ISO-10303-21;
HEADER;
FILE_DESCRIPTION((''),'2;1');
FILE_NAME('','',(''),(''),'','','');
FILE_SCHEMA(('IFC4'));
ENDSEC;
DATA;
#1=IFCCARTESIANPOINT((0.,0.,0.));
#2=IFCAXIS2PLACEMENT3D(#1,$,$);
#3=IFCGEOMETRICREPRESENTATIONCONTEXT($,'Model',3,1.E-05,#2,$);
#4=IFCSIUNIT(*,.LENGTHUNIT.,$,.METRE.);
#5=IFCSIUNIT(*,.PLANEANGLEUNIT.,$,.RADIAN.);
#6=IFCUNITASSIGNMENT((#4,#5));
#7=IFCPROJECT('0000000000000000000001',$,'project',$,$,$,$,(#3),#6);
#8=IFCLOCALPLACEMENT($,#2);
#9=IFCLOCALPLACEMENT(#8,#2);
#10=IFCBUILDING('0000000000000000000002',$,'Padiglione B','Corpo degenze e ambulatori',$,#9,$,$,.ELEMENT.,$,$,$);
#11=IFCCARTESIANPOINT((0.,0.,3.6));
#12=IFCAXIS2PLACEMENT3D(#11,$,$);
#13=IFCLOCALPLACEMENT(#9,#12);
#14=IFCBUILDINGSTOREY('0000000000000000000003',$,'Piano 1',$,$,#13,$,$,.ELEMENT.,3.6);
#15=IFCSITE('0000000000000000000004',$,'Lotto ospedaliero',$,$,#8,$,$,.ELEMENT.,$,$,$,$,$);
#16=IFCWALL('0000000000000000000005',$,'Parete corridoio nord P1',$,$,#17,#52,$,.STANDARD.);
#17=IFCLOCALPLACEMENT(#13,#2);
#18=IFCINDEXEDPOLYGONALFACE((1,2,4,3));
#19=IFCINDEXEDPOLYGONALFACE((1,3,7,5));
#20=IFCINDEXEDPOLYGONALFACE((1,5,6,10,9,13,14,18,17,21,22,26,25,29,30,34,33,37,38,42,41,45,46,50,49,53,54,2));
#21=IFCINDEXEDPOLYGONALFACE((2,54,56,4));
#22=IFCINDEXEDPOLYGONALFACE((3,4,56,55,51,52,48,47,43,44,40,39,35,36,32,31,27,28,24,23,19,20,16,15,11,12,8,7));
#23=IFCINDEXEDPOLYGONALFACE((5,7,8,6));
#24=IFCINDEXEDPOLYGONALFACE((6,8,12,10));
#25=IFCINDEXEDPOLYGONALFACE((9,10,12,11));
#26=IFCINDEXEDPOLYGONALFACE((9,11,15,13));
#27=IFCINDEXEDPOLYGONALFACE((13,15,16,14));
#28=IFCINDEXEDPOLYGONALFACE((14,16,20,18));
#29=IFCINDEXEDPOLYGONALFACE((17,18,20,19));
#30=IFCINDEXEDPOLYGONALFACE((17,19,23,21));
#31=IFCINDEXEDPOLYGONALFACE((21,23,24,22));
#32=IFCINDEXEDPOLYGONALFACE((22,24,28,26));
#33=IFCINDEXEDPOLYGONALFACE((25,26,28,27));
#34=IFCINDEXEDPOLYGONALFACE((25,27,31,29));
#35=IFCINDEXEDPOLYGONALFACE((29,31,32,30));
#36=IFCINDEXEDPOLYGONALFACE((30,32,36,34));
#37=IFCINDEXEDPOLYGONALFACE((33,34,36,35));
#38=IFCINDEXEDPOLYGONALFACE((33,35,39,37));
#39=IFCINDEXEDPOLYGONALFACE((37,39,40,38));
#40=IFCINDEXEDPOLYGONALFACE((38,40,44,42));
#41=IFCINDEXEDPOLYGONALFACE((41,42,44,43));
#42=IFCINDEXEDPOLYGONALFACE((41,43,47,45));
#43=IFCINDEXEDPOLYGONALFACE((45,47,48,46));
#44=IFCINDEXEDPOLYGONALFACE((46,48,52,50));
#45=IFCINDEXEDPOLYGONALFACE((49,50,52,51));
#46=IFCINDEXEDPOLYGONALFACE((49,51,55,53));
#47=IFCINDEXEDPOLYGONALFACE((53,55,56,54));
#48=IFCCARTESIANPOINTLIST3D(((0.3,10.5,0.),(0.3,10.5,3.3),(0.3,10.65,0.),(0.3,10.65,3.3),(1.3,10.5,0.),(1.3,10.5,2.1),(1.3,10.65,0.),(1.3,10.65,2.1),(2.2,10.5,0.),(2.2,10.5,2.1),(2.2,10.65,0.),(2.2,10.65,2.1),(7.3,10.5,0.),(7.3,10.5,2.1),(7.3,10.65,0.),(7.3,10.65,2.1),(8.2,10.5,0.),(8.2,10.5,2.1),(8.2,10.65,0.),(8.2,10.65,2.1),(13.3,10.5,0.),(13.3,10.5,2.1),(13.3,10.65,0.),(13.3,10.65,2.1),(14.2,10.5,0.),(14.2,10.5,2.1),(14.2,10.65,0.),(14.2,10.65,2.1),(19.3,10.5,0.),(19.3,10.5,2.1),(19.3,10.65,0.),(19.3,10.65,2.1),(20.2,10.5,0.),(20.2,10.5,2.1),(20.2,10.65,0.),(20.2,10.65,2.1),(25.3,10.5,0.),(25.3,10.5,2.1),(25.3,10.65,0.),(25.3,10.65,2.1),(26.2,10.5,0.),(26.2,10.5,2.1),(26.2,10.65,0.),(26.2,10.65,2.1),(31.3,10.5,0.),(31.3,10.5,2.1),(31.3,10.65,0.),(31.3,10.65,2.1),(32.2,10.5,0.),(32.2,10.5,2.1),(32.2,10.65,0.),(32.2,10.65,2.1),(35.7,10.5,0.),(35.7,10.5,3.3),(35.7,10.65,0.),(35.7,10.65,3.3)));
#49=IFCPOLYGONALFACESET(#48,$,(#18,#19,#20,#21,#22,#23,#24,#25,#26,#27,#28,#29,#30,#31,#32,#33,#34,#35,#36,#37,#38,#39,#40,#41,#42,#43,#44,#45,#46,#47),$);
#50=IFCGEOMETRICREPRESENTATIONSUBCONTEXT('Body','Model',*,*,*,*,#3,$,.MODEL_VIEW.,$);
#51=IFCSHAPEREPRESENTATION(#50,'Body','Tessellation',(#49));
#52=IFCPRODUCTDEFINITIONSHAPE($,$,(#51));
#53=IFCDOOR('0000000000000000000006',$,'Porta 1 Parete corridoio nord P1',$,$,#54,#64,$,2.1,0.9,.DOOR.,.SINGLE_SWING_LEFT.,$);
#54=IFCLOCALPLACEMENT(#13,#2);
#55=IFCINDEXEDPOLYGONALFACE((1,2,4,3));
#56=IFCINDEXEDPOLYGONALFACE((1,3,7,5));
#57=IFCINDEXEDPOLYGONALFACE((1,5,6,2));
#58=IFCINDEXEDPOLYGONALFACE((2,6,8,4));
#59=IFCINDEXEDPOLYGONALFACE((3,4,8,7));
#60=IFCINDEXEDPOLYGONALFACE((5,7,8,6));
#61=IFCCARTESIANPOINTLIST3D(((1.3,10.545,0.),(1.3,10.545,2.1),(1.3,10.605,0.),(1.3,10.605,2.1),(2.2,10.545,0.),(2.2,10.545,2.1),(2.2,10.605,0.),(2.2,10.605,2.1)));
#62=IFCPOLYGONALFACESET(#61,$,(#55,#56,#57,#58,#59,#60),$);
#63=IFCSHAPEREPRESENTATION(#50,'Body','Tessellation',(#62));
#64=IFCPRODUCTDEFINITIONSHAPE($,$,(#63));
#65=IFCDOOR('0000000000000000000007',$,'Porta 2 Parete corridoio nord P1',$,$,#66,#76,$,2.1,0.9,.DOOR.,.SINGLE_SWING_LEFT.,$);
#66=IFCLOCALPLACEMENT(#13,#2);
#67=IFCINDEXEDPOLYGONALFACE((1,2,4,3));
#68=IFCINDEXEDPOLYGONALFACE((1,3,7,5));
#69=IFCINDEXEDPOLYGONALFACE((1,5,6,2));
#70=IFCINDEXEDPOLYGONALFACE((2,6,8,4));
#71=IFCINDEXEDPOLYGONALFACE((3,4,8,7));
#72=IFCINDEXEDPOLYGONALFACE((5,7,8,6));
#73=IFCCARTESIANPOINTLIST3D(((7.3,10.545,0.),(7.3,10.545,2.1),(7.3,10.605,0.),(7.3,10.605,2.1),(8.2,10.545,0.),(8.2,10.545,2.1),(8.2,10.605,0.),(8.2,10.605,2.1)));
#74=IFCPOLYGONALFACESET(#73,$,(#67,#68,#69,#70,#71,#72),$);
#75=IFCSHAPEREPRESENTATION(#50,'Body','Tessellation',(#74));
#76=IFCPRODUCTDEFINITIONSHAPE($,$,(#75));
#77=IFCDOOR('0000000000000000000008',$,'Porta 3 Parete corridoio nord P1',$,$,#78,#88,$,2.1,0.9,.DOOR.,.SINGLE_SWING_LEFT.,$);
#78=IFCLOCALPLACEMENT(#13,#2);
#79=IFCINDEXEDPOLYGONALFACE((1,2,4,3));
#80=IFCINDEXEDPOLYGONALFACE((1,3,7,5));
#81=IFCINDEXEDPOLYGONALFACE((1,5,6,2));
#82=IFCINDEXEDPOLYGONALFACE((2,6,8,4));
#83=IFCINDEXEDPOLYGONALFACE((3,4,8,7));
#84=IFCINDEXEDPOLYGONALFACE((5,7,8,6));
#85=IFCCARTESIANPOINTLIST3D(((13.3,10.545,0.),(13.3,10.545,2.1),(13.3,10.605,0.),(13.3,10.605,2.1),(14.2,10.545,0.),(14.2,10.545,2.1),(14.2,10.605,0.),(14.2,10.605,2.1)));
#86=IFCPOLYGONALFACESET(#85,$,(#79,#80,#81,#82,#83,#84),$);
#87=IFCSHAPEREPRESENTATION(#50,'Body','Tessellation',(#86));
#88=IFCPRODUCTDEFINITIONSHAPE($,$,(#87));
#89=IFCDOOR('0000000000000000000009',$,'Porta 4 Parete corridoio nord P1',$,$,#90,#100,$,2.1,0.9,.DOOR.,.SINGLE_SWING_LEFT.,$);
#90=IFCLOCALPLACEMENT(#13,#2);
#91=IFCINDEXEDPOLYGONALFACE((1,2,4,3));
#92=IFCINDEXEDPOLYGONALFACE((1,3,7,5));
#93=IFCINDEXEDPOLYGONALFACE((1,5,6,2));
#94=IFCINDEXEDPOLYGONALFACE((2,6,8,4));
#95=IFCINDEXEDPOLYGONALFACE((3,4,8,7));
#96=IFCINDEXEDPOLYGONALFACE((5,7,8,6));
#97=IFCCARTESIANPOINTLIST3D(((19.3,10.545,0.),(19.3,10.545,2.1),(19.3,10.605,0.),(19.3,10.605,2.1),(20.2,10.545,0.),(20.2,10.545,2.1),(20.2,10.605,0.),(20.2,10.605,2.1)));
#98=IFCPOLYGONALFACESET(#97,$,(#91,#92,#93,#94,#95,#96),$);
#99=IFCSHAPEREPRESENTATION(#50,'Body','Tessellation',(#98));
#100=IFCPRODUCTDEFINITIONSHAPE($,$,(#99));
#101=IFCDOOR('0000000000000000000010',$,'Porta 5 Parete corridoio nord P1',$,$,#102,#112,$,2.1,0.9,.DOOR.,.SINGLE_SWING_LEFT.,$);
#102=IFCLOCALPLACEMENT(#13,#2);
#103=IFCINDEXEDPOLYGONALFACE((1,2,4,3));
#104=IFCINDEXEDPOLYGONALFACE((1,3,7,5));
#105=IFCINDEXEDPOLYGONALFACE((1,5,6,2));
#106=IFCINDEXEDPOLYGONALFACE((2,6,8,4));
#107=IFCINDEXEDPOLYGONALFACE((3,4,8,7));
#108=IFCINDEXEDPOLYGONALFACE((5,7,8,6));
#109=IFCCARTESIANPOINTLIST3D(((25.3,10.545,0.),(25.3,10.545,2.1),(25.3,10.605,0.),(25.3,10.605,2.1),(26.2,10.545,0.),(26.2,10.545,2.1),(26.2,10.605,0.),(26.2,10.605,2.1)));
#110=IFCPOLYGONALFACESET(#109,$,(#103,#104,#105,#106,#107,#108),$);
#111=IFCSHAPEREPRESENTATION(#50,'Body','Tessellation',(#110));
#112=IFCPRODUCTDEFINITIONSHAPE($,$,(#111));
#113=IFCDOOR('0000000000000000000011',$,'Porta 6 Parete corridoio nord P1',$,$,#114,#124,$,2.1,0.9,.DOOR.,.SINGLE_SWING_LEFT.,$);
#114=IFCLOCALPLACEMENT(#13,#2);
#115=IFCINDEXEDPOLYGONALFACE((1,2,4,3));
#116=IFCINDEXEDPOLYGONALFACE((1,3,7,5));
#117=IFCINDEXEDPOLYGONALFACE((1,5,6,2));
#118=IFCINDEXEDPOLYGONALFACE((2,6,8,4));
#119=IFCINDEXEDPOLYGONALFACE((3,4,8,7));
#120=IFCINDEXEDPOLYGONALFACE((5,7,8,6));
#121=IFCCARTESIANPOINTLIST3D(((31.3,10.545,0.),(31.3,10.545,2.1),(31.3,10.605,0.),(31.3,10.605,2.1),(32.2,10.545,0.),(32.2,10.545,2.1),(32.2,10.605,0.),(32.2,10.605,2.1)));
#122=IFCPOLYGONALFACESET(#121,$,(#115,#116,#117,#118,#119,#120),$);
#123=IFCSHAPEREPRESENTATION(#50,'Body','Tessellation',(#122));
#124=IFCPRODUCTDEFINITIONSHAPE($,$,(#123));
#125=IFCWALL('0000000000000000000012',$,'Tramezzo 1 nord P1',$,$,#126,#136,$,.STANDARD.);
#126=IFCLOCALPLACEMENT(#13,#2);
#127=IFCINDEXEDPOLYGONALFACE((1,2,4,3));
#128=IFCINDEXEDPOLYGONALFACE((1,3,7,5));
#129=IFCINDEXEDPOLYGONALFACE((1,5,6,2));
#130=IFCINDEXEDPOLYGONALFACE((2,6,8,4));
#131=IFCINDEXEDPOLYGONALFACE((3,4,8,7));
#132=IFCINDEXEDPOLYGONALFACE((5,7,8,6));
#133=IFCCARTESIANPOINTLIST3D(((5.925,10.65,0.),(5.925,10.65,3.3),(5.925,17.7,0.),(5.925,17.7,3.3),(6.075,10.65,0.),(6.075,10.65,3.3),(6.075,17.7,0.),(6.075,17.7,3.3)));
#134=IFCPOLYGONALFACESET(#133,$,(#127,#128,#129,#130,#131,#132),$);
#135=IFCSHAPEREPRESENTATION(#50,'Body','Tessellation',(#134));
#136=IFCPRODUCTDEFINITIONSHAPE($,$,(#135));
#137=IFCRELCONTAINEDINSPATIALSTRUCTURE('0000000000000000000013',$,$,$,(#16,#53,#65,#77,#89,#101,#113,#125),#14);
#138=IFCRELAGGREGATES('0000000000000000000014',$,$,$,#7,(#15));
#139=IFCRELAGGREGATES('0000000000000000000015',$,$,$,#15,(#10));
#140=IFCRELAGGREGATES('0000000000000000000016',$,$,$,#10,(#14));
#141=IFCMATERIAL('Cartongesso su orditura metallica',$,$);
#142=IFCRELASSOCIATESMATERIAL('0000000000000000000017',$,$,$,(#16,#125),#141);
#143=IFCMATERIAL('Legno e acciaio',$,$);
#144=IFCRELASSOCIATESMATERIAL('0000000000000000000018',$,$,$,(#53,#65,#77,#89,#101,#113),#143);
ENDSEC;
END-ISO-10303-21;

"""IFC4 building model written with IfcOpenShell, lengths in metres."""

from ifc_helpers import new_model, si_unit, frame, frame_2d, origin, place, context, subcontext, project, spatial, rectangle, extrude, material, element, fill, save


model = new_model("IFC4")

# Units and contexts
model_context = context("Model", 3, precision=1e-05, world=origin())
body_context = subcontext(model_context, "Body", "Model", "MODEL_VIEW")
ifc_project = project(units=[si_unit("LENGTHUNIT", "METRE"), si_unit("PLANEANGLEUNIT", "RADIAN")], contexts=[model_context])

# Site, building, storey
site_placement = place(None, origin())
site = spatial("IfcSite", under=ifc_project, at=site_placement, Name="Lotto ospedaliero", CompositionType="ELEMENT")
building_placement = place(site_placement, origin())
building = spatial("IfcBuilding", under=site, at=building_placement, Name="Padiglione B", Description="Corpo degenze e ambulatori", CompositionType="ELEMENT")
storey_placement = place(building_placement, frame((0.0, 0.0, 3.6)))
storey = spatial("IfcBuildingStorey", under=building, at=storey_placement, Name="Piano 1", CompositionType="ELEMENT", Elevation=3.6)

# Wall, openings, doors
ifc_material_1 = material(Name="Cartongesso su orditura metallica")
ifc_material_2 = material(Name="Legno e acciaio")
wall_1_placement = place(storey_placement, frame((0.3, 10.5, 0.0)))
wall_1 = element("IfcWall", 1, at=wall_1_placement, inside=storey, material=ifc_material_1, Name="Parete corridoio nord P1", PredefinedType="STANDARD", context=body_context, shape_type="SweptSolid", body=[
    extrude(rectangle(XDim=35.4, YDim=0.15, at=frame_2d((17.7, 0.075))), origin(), (0.0, 0.0, 1.0), 3.3),
])
opening_1_placement = place(wall_1_placement, frame((1.0, -0.1, 0.0)))
opening_1 = element("IfcOpeningElement", 2, at=opening_1_placement, cuts=wall_1, PredefinedType="OPENING", context=body_context, shape_type="SweptSolid", body=[
    extrude(rectangle(XDim=0.9, YDim=0.35, at=frame_2d((0.45, 0.175))), origin(), (0.0, 0.0, 1.0), 2.1),
])
opening_2_placement = place(wall_1_placement, frame((7.0, -0.1, 0.0)))
opening_2 = element("IfcOpeningElement", 3, at=opening_2_placement, cuts=wall_1, PredefinedType="OPENING", context=body_context, shape_type="SweptSolid", body=[
    extrude(rectangle(XDim=0.9, YDim=0.35, at=frame_2d((0.45, 0.175))), origin(), (0.0, 0.0, 1.0), 2.1),
])
opening_3_placement = place(wall_1_placement, frame((13.0, -0.1, 0.0)))
opening_3 = element("IfcOpeningElement", 4, at=opening_3_placement, cuts=wall_1, PredefinedType="OPENING", context=body_context, shape_type="SweptSolid", body=[
    extrude(rectangle(XDim=0.9, YDim=0.35, at=frame_2d((0.45, 0.175))), origin(), (0.0, 0.0, 1.0), 2.1),
])
opening_4_placement = place(wall_1_placement, frame((19.0, -0.1, 0.0)))
opening_4 = element("IfcOpeningElement", 5, at=opening_4_placement, cuts=wall_1, PredefinedType="OPENING", context=body_context, shape_type="SweptSolid", body=[
    extrude(rectangle(XDim=0.9, YDim=0.35, at=frame_2d((0.45, 0.175))), origin(), (0.0, 0.0, 1.0), 2.1),
])
opening_5_placement = place(wall_1_placement, frame((25.0, -0.1, 0.0)))
opening_5 = element("IfcOpeningElement", 6, at=opening_5_placement, cuts=wall_1, PredefinedType="OPENING", context=body_context, shape_type="SweptSolid", body=[
    extrude(rectangle(XDim=0.9, YDim=0.35, at=frame_2d((0.45, 0.175))), origin(), (0.0, 0.0, 1.0), 2.1),
])
opening_6_placement = place(wall_1_placement, frame((31.0, -0.1, 0.0)))
opening_6 = element("IfcOpeningElement", 7, at=opening_6_placement, cuts=wall_1, PredefinedType="OPENING", context=body_context, shape_type="SweptSolid", body=[
    extrude(rectangle(XDim=0.9, YDim=0.35, at=frame_2d((0.45, 0.175))), origin(), (0.0, 0.0, 1.0), 2.1),
])
door_1_placement = place(wall_1_placement, frame((1.0, 0.045, 0.0)))
door_1 = element("IfcDoor", 8, at=door_1_placement, inside=storey, material=ifc_material_2, Name="Porta 1 Parete corridoio nord P1", OperationType="SINGLE_SWING_LEFT", OverallHeight=2.1, OverallWidth=0.9, PredefinedType="DOOR", context=body_context, shape_type="SweptSolid", body=[
    extrude(rectangle(XDim=0.9, YDim=0.06, at=frame_2d((0.45, 0.03))), origin(), (0.0, 0.0, 1.0), 2.1),
])
fill(opening_1, door_1)
door_2_placement = place(wall_1_placement, frame((7.0, 0.045, 0.0)))
door_2 = element("IfcDoor", 9, at=door_2_placement, inside=storey, material=ifc_material_2, Name="Porta 2 Parete corridoio nord P1", OperationType="SINGLE_SWING_LEFT", OverallHeight=2.1, OverallWidth=0.9, PredefinedType="DOOR", context=body_context, shape_type="SweptSolid", body=[
    extrude(rectangle(XDim=0.9, YDim=0.06, at=frame_2d((0.45, 0.03))), origin(), (0.0, 0.0, 1.0), 2.1),
])
fill(opening_2, door_2)
door_3_placement = place(wall_1_placement, frame((13.0, 0.045, 0.0)))
door_3 = element("IfcDoor", 10, at=door_3_placement, inside=storey, material=ifc_material_2, Name="Porta 3 Parete corridoio nord P1", OperationType="SINGLE_SWING_LEFT", OverallHeight=2.1, OverallWidth=0.9, PredefinedType="DOOR", context=body_context, shape_type="SweptSolid", body=[
    extrude(rectangle(XDim=0.9, YDim=0.06, at=frame_2d((0.45, 0.03))), origin(), (0.0, 0.0, 1.0), 2.1),
])
fill(opening_3, door_3)
door_4_placement = place(wall_1_placement, frame((19.0, 0.045, 0.0)))
door_4 = element("IfcDoor", 11, at=door_4_placement, inside=storey, material=ifc_material_2, Name="Porta 4 Parete corridoio nord P1", OperationType="SINGLE_SWING_LEFT", OverallHeight=2.1, OverallWidth=0.9, PredefinedType="DOOR", context=body_context, shape_type="SweptSolid", body=[
    extrude(rectangle(XDim=0.9, YDim=0.06, at=frame_2d((0.45, 0.03))), origin(), (0.0, 0.0, 1.0), 2.1),
])
fill(opening_4, door_4)
door_5_placement = place(wall_1_placement, frame((25.0, 0.045, 0.0)))
door_5 = element("IfcDoor", 12, at=door_5_placement, inside=storey, material=ifc_material_2, Name="Porta 5 Parete corridoio nord P1", OperationType="SINGLE_SWING_LEFT", OverallHeight=2.1, OverallWidth=0.9, PredefinedType="DOOR", context=body_context, shape_type="SweptSolid", body=[
    extrude(rectangle(XDim=0.9, YDim=0.06, at=frame_2d((0.45, 0.03))), origin(), (0.0, 0.0, 1.0), 2.1),
])
fill(opening_5, door_5)
door_6_placement = place(wall_1_placement, frame((31.0, 0.045, 0.0)))
door_6 = element("IfcDoor", 13, at=door_6_placement, inside=storey, material=ifc_material_2, Name="Porta 6 Parete corridoio nord P1", OperationType="SINGLE_SWING_LEFT", OverallHeight=2.1, OverallWidth=0.9, PredefinedType="DOOR", context=body_context, shape_type="SweptSolid", body=[
    extrude(rectangle(XDim=0.9, YDim=0.06, at=frame_2d((0.45, 0.03))), origin(), (0.0, 0.0, 1.0), 2.1),
])
fill(opening_6, door_6)

# Wall
wall_2_placement = place(storey_placement, frame((5.925, 10.65, 0.0)))
element("IfcWall", 14, at=wall_2_placement, inside=storey, material=ifc_material_1, Name="Tramezzo 1 nord P1", PredefinedType="STANDARD", context=body_context, shape_type="SweptSolid", body=[
    extrude(rectangle(XDim=0.15, YDim=7.05, at=frame_2d((0.075, 3.525))), origin(), (0.0, 0.0, 1.0), 3.3),
])

save(model, "model.ifc")
